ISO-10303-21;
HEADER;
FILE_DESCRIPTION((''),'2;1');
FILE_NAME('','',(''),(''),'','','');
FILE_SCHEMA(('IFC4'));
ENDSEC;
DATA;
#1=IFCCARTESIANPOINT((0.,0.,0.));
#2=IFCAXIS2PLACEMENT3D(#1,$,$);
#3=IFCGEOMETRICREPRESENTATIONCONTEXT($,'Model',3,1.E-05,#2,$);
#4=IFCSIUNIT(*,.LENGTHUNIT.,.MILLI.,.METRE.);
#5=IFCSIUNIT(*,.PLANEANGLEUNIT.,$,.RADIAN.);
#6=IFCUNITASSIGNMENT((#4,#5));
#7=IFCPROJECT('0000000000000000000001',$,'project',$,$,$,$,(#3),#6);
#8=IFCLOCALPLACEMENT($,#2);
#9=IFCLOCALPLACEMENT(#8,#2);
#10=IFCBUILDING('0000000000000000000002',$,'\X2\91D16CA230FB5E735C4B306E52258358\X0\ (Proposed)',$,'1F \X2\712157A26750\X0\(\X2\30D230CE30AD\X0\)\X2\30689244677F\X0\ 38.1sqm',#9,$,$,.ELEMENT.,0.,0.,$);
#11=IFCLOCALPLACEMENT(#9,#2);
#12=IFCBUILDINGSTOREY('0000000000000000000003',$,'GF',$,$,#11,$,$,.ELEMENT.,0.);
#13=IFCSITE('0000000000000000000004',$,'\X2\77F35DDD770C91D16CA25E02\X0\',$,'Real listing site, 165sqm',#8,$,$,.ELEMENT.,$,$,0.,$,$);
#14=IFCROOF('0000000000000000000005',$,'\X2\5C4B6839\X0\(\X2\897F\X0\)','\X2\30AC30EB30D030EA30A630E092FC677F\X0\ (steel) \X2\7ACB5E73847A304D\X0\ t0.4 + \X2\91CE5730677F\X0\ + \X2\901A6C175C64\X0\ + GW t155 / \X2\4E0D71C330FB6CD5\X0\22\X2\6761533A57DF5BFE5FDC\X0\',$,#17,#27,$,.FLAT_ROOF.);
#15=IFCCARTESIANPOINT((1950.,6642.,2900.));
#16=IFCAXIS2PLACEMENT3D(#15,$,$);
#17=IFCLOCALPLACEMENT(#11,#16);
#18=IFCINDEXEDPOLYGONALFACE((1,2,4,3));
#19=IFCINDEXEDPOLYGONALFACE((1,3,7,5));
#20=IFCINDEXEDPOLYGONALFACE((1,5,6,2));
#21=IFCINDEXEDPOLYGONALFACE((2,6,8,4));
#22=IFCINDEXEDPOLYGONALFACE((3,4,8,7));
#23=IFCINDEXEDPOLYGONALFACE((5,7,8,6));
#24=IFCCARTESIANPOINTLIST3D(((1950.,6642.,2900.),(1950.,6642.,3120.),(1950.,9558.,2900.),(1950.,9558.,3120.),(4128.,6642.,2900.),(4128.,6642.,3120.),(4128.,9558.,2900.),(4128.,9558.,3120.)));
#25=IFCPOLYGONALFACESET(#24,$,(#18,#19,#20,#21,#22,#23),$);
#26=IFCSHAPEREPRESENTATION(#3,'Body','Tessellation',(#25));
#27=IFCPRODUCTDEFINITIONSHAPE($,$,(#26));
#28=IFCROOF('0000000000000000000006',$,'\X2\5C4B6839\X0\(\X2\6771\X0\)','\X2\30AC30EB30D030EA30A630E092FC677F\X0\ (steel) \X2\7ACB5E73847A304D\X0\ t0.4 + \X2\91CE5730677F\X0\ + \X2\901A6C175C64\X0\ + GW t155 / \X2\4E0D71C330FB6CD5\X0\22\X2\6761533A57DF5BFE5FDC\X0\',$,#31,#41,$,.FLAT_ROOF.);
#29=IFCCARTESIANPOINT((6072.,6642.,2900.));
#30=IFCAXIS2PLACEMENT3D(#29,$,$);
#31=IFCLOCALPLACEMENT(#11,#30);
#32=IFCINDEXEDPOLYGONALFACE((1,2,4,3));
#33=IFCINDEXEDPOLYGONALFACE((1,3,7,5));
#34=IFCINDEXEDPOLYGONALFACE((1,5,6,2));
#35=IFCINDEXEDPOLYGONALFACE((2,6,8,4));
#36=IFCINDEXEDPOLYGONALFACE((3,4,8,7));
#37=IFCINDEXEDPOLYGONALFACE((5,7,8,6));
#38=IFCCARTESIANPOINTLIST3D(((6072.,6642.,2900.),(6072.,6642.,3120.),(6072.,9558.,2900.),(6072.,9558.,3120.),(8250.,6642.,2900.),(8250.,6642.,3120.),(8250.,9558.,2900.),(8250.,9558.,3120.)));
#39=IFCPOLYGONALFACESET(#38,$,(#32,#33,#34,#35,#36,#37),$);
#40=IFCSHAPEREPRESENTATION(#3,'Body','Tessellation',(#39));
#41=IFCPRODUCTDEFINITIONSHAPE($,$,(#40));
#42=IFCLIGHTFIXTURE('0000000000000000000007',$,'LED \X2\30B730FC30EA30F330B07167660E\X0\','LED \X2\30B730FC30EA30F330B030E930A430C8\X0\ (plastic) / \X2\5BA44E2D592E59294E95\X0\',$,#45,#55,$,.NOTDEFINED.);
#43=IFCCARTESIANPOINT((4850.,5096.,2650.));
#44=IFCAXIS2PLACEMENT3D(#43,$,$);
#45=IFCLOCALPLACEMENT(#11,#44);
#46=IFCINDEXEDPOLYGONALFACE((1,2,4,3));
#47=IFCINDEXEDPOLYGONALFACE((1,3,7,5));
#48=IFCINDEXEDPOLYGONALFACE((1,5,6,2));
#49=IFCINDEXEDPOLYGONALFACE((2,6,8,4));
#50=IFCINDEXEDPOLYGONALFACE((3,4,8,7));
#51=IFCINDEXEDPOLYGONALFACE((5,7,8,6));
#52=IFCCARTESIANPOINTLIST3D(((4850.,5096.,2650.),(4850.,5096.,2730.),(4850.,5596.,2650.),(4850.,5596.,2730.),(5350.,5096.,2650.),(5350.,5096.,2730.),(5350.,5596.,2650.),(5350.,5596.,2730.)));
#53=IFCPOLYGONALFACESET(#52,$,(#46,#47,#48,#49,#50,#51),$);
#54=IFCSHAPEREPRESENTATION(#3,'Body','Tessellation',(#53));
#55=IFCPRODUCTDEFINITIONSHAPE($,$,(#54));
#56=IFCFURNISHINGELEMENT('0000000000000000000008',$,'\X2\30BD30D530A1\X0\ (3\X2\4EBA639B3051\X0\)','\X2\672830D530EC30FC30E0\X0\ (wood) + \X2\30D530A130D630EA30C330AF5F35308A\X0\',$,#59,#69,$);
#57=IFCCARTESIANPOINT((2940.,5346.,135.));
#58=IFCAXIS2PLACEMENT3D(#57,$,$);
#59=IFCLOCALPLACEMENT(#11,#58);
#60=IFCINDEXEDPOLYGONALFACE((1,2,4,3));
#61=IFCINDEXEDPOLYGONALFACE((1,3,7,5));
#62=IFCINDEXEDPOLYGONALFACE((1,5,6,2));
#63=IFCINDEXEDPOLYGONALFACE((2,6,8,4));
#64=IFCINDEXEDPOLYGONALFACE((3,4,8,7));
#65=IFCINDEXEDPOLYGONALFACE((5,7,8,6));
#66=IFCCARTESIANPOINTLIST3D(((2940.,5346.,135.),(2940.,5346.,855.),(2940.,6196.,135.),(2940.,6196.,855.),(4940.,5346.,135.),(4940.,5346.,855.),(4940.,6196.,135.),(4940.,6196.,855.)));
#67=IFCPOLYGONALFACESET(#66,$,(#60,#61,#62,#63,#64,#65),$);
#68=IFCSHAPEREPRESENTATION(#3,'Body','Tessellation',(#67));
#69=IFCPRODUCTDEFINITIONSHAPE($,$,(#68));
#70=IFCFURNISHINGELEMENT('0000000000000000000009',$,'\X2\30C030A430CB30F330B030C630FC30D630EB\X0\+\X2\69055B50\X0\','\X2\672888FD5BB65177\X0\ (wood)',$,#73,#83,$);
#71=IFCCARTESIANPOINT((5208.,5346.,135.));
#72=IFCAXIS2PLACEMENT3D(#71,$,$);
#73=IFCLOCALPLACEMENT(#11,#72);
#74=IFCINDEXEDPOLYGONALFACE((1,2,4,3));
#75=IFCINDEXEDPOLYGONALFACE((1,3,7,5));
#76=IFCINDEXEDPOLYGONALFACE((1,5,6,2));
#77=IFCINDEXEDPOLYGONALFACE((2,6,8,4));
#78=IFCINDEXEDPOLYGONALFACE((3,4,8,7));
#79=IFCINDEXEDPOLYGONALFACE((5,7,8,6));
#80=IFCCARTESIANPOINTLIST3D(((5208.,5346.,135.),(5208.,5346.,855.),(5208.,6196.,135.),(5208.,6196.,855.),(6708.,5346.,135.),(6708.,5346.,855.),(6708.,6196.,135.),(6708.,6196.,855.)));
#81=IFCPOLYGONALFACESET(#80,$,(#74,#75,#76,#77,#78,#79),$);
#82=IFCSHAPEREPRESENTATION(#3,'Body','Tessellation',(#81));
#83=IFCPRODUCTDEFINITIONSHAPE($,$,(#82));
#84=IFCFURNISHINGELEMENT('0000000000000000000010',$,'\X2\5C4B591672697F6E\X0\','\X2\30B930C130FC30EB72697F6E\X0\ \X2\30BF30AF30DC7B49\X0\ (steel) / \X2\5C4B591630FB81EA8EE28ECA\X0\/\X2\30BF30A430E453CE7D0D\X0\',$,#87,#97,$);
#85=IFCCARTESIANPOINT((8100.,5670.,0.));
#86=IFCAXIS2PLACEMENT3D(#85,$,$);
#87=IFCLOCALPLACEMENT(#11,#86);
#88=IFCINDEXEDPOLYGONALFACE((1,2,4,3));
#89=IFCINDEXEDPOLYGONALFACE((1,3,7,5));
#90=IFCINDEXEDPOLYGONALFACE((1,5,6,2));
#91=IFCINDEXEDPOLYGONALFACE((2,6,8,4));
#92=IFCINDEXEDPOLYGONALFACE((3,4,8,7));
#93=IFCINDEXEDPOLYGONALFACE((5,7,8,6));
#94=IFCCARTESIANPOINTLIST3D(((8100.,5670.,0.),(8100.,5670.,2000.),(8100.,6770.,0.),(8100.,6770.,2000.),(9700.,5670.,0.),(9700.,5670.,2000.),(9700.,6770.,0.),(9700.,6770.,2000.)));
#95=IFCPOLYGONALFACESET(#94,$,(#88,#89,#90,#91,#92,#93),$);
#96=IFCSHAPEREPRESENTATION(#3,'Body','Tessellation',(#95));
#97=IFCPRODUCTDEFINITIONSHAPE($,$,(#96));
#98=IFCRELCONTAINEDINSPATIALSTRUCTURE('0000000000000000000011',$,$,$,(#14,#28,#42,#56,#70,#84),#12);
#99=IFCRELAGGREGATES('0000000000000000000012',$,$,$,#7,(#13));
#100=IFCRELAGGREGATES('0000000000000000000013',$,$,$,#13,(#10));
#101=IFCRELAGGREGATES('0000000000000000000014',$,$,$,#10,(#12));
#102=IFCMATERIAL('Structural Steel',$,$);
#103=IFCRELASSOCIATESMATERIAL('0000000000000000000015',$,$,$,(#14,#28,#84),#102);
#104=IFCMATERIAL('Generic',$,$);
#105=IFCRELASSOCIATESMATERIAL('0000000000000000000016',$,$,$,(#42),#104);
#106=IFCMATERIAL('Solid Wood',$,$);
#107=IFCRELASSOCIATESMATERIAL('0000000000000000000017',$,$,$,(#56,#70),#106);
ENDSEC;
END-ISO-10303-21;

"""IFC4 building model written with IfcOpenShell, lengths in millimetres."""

from ifc_helpers import new_model, si_unit, frame, frame_2d, origin, place, context, project, spatial, rectangle, extrude, material, element, save


model = new_model("IFC4")

# Units and contexts
model_context = context("Model", 3, precision=1e-05, world=origin())
ifc_project = project(units=[si_unit("LENGTHUNIT", "METRE", prefix="MILLI"), si_unit("PLANEANGLEUNIT", "RADIAN")], contexts=[model_context])

# Site, building, storey
site_placement = place(None, origin())
site = spatial("IfcSite", under=ifc_project, at=site_placement, Name="石川県金沢市", ObjectType="Real listing site, 165sqm", CompositionType="ELEMENT", RefElevation=0.0)
building_placement = place(site_placement, origin())
building = spatial("IfcBuilding", under=site, at=building_placement, Name="金沢・平屋の別荘 (Proposed)", ObjectType="1F 無垢材(ヒノキ)と鉄板 38.1sqm", CompositionType="ELEMENT", ElevationOfRefHeight=0.0, ElevationOfTerrain=0.0)
storey_placement = place(building_placement, origin())
storey = spatial("IfcBuildingStorey", under=building, at=storey_placement, Name="GF", CompositionType="ELEMENT", Elevation=0.0)

# Shared definitions
ifc_material_1 = material(Name="Solid Wood")

# Roofs
ifc_material_2 = material(Name="Structural Steel")
roof_1_placement = place(storey_placement, frame((1950.0, 6642.0, 2900.0)))
element("IfcRoof", 1, at=roof_1_placement, inside=storey, material=ifc_material_2, Name="屋根(西)", Description="ガルバリウム鋼板 (steel) 立平葺き t0.4 + 野地板 + 通気層 + GW t155 / 不燃・法22条区域対応", PredefinedType="FLAT_ROOF", context=model_context, shape_type="SweptSolid", body=[
    extrude(rectangle(XDim=2178.0, YDim=2916.0, at=frame_2d((1089.0, 1458.0))), frame((1950.0, 6642.0, 2900.0)), (0.0, 0.0, 1.0), 220.0),
])
roof_2_placement = place(storey_placement, frame((6072.0, 6642.0, 2900.0)))
element("IfcRoof", 2, at=roof_2_placement, inside=storey, material=ifc_material_2, Name="屋根(東)", Description="ガルバリウム鋼板 (steel) 立平葺き t0.4 + 野地板 + 通気層 + GW t155 / 不燃・法22条区域対応", PredefinedType="FLAT_ROOF", context=model_context, shape_type="SweptSolid", body=[
    extrude(rectangle(XDim=2178.0, YDim=2916.0, at=frame_2d((1089.0, 1458.0))), frame((6072.0, 6642.0, 2900.0)), (0.0, 0.0, 1.0), 220.0),
])

# Light fixture
ifc_material_3 = material(Name="Generic")
light_fixture_placement = place(storey_placement, frame((4850.0, 5096.0, 2650.0)))
element("IfcLightFixture", 3, at=light_fixture_placement, inside=storey, material=ifc_material_3, Name="LED シーリング照明", Description="LED シーリングライト (plastic) / 室中央天井", PredefinedType="NOTDEFINED", context=model_context, shape_type="SweptSolid", body=[
    extrude(rectangle(XDim=500.0, YDim=500.0, at=frame_2d((250.0, 250.0))), frame((4850.0, 5096.0, 2650.0)), (0.0, 0.0, 1.0), 80.0),
])

# Furnishing elements
furnishing_1_placement = place(storey_placement, frame((2940.0, 5346.0, 135.0)))
element("IfcFurnishingElement", 4, at=furnishing_1_placement, inside=storey, material=ifc_material_1, Name="ソファ (3人掛け)", Description="木フレーム (wood) + ファブリック張り", context=model_context, shape_type="SweptSolid", body=[
    extrude(rectangle(XDim=2000.0, YDim=850.0, at=frame_2d((1000.0, 425.0))), frame((2940.0, 5346.0, 135.0)), (0.0, 0.0, 1.0), 720.0),
])
furnishing_2_placement = place(storey_placement, frame((5208.0, 5346.0, 135.0)))
element("IfcFurnishingElement", 5, at=furnishing_2_placement, inside=storey, material=ifc_material_1, Name="ダイニングテーブル+椅子", Description="木製家具 (wood)", context=model_context, shape_type="SweptSolid", body=[
    extrude(rectangle(XDim=1500.0, YDim=850.0, at=frame_2d((750.0, 425.0))), frame((5208.0, 5346.0, 135.0)), (0.0, 0.0, 1.0), 720.0),
])
furnishing_3_placement = place(storey_placement, frame((8100.0, 5670.0, 0.0)))
element("IfcFurnishingElement", 6, at=furnishing_3_placement, inside=storey, material=ifc_material_2, Name="屋外物置", Description="スチール物置 タクボ等 (steel) / 屋外・自転車/タイヤ収納", context=model_context, shape_type="SweptSolid", body=[
    extrude(rectangle(XDim=1600.0, YDim=1100.0, at=frame_2d((800.0, 550.0))), frame((8100.0, 5670.0, 0.0)), (0.0, 0.0, 1.0), 2000.0),
])

save(model, "model.ifc")
